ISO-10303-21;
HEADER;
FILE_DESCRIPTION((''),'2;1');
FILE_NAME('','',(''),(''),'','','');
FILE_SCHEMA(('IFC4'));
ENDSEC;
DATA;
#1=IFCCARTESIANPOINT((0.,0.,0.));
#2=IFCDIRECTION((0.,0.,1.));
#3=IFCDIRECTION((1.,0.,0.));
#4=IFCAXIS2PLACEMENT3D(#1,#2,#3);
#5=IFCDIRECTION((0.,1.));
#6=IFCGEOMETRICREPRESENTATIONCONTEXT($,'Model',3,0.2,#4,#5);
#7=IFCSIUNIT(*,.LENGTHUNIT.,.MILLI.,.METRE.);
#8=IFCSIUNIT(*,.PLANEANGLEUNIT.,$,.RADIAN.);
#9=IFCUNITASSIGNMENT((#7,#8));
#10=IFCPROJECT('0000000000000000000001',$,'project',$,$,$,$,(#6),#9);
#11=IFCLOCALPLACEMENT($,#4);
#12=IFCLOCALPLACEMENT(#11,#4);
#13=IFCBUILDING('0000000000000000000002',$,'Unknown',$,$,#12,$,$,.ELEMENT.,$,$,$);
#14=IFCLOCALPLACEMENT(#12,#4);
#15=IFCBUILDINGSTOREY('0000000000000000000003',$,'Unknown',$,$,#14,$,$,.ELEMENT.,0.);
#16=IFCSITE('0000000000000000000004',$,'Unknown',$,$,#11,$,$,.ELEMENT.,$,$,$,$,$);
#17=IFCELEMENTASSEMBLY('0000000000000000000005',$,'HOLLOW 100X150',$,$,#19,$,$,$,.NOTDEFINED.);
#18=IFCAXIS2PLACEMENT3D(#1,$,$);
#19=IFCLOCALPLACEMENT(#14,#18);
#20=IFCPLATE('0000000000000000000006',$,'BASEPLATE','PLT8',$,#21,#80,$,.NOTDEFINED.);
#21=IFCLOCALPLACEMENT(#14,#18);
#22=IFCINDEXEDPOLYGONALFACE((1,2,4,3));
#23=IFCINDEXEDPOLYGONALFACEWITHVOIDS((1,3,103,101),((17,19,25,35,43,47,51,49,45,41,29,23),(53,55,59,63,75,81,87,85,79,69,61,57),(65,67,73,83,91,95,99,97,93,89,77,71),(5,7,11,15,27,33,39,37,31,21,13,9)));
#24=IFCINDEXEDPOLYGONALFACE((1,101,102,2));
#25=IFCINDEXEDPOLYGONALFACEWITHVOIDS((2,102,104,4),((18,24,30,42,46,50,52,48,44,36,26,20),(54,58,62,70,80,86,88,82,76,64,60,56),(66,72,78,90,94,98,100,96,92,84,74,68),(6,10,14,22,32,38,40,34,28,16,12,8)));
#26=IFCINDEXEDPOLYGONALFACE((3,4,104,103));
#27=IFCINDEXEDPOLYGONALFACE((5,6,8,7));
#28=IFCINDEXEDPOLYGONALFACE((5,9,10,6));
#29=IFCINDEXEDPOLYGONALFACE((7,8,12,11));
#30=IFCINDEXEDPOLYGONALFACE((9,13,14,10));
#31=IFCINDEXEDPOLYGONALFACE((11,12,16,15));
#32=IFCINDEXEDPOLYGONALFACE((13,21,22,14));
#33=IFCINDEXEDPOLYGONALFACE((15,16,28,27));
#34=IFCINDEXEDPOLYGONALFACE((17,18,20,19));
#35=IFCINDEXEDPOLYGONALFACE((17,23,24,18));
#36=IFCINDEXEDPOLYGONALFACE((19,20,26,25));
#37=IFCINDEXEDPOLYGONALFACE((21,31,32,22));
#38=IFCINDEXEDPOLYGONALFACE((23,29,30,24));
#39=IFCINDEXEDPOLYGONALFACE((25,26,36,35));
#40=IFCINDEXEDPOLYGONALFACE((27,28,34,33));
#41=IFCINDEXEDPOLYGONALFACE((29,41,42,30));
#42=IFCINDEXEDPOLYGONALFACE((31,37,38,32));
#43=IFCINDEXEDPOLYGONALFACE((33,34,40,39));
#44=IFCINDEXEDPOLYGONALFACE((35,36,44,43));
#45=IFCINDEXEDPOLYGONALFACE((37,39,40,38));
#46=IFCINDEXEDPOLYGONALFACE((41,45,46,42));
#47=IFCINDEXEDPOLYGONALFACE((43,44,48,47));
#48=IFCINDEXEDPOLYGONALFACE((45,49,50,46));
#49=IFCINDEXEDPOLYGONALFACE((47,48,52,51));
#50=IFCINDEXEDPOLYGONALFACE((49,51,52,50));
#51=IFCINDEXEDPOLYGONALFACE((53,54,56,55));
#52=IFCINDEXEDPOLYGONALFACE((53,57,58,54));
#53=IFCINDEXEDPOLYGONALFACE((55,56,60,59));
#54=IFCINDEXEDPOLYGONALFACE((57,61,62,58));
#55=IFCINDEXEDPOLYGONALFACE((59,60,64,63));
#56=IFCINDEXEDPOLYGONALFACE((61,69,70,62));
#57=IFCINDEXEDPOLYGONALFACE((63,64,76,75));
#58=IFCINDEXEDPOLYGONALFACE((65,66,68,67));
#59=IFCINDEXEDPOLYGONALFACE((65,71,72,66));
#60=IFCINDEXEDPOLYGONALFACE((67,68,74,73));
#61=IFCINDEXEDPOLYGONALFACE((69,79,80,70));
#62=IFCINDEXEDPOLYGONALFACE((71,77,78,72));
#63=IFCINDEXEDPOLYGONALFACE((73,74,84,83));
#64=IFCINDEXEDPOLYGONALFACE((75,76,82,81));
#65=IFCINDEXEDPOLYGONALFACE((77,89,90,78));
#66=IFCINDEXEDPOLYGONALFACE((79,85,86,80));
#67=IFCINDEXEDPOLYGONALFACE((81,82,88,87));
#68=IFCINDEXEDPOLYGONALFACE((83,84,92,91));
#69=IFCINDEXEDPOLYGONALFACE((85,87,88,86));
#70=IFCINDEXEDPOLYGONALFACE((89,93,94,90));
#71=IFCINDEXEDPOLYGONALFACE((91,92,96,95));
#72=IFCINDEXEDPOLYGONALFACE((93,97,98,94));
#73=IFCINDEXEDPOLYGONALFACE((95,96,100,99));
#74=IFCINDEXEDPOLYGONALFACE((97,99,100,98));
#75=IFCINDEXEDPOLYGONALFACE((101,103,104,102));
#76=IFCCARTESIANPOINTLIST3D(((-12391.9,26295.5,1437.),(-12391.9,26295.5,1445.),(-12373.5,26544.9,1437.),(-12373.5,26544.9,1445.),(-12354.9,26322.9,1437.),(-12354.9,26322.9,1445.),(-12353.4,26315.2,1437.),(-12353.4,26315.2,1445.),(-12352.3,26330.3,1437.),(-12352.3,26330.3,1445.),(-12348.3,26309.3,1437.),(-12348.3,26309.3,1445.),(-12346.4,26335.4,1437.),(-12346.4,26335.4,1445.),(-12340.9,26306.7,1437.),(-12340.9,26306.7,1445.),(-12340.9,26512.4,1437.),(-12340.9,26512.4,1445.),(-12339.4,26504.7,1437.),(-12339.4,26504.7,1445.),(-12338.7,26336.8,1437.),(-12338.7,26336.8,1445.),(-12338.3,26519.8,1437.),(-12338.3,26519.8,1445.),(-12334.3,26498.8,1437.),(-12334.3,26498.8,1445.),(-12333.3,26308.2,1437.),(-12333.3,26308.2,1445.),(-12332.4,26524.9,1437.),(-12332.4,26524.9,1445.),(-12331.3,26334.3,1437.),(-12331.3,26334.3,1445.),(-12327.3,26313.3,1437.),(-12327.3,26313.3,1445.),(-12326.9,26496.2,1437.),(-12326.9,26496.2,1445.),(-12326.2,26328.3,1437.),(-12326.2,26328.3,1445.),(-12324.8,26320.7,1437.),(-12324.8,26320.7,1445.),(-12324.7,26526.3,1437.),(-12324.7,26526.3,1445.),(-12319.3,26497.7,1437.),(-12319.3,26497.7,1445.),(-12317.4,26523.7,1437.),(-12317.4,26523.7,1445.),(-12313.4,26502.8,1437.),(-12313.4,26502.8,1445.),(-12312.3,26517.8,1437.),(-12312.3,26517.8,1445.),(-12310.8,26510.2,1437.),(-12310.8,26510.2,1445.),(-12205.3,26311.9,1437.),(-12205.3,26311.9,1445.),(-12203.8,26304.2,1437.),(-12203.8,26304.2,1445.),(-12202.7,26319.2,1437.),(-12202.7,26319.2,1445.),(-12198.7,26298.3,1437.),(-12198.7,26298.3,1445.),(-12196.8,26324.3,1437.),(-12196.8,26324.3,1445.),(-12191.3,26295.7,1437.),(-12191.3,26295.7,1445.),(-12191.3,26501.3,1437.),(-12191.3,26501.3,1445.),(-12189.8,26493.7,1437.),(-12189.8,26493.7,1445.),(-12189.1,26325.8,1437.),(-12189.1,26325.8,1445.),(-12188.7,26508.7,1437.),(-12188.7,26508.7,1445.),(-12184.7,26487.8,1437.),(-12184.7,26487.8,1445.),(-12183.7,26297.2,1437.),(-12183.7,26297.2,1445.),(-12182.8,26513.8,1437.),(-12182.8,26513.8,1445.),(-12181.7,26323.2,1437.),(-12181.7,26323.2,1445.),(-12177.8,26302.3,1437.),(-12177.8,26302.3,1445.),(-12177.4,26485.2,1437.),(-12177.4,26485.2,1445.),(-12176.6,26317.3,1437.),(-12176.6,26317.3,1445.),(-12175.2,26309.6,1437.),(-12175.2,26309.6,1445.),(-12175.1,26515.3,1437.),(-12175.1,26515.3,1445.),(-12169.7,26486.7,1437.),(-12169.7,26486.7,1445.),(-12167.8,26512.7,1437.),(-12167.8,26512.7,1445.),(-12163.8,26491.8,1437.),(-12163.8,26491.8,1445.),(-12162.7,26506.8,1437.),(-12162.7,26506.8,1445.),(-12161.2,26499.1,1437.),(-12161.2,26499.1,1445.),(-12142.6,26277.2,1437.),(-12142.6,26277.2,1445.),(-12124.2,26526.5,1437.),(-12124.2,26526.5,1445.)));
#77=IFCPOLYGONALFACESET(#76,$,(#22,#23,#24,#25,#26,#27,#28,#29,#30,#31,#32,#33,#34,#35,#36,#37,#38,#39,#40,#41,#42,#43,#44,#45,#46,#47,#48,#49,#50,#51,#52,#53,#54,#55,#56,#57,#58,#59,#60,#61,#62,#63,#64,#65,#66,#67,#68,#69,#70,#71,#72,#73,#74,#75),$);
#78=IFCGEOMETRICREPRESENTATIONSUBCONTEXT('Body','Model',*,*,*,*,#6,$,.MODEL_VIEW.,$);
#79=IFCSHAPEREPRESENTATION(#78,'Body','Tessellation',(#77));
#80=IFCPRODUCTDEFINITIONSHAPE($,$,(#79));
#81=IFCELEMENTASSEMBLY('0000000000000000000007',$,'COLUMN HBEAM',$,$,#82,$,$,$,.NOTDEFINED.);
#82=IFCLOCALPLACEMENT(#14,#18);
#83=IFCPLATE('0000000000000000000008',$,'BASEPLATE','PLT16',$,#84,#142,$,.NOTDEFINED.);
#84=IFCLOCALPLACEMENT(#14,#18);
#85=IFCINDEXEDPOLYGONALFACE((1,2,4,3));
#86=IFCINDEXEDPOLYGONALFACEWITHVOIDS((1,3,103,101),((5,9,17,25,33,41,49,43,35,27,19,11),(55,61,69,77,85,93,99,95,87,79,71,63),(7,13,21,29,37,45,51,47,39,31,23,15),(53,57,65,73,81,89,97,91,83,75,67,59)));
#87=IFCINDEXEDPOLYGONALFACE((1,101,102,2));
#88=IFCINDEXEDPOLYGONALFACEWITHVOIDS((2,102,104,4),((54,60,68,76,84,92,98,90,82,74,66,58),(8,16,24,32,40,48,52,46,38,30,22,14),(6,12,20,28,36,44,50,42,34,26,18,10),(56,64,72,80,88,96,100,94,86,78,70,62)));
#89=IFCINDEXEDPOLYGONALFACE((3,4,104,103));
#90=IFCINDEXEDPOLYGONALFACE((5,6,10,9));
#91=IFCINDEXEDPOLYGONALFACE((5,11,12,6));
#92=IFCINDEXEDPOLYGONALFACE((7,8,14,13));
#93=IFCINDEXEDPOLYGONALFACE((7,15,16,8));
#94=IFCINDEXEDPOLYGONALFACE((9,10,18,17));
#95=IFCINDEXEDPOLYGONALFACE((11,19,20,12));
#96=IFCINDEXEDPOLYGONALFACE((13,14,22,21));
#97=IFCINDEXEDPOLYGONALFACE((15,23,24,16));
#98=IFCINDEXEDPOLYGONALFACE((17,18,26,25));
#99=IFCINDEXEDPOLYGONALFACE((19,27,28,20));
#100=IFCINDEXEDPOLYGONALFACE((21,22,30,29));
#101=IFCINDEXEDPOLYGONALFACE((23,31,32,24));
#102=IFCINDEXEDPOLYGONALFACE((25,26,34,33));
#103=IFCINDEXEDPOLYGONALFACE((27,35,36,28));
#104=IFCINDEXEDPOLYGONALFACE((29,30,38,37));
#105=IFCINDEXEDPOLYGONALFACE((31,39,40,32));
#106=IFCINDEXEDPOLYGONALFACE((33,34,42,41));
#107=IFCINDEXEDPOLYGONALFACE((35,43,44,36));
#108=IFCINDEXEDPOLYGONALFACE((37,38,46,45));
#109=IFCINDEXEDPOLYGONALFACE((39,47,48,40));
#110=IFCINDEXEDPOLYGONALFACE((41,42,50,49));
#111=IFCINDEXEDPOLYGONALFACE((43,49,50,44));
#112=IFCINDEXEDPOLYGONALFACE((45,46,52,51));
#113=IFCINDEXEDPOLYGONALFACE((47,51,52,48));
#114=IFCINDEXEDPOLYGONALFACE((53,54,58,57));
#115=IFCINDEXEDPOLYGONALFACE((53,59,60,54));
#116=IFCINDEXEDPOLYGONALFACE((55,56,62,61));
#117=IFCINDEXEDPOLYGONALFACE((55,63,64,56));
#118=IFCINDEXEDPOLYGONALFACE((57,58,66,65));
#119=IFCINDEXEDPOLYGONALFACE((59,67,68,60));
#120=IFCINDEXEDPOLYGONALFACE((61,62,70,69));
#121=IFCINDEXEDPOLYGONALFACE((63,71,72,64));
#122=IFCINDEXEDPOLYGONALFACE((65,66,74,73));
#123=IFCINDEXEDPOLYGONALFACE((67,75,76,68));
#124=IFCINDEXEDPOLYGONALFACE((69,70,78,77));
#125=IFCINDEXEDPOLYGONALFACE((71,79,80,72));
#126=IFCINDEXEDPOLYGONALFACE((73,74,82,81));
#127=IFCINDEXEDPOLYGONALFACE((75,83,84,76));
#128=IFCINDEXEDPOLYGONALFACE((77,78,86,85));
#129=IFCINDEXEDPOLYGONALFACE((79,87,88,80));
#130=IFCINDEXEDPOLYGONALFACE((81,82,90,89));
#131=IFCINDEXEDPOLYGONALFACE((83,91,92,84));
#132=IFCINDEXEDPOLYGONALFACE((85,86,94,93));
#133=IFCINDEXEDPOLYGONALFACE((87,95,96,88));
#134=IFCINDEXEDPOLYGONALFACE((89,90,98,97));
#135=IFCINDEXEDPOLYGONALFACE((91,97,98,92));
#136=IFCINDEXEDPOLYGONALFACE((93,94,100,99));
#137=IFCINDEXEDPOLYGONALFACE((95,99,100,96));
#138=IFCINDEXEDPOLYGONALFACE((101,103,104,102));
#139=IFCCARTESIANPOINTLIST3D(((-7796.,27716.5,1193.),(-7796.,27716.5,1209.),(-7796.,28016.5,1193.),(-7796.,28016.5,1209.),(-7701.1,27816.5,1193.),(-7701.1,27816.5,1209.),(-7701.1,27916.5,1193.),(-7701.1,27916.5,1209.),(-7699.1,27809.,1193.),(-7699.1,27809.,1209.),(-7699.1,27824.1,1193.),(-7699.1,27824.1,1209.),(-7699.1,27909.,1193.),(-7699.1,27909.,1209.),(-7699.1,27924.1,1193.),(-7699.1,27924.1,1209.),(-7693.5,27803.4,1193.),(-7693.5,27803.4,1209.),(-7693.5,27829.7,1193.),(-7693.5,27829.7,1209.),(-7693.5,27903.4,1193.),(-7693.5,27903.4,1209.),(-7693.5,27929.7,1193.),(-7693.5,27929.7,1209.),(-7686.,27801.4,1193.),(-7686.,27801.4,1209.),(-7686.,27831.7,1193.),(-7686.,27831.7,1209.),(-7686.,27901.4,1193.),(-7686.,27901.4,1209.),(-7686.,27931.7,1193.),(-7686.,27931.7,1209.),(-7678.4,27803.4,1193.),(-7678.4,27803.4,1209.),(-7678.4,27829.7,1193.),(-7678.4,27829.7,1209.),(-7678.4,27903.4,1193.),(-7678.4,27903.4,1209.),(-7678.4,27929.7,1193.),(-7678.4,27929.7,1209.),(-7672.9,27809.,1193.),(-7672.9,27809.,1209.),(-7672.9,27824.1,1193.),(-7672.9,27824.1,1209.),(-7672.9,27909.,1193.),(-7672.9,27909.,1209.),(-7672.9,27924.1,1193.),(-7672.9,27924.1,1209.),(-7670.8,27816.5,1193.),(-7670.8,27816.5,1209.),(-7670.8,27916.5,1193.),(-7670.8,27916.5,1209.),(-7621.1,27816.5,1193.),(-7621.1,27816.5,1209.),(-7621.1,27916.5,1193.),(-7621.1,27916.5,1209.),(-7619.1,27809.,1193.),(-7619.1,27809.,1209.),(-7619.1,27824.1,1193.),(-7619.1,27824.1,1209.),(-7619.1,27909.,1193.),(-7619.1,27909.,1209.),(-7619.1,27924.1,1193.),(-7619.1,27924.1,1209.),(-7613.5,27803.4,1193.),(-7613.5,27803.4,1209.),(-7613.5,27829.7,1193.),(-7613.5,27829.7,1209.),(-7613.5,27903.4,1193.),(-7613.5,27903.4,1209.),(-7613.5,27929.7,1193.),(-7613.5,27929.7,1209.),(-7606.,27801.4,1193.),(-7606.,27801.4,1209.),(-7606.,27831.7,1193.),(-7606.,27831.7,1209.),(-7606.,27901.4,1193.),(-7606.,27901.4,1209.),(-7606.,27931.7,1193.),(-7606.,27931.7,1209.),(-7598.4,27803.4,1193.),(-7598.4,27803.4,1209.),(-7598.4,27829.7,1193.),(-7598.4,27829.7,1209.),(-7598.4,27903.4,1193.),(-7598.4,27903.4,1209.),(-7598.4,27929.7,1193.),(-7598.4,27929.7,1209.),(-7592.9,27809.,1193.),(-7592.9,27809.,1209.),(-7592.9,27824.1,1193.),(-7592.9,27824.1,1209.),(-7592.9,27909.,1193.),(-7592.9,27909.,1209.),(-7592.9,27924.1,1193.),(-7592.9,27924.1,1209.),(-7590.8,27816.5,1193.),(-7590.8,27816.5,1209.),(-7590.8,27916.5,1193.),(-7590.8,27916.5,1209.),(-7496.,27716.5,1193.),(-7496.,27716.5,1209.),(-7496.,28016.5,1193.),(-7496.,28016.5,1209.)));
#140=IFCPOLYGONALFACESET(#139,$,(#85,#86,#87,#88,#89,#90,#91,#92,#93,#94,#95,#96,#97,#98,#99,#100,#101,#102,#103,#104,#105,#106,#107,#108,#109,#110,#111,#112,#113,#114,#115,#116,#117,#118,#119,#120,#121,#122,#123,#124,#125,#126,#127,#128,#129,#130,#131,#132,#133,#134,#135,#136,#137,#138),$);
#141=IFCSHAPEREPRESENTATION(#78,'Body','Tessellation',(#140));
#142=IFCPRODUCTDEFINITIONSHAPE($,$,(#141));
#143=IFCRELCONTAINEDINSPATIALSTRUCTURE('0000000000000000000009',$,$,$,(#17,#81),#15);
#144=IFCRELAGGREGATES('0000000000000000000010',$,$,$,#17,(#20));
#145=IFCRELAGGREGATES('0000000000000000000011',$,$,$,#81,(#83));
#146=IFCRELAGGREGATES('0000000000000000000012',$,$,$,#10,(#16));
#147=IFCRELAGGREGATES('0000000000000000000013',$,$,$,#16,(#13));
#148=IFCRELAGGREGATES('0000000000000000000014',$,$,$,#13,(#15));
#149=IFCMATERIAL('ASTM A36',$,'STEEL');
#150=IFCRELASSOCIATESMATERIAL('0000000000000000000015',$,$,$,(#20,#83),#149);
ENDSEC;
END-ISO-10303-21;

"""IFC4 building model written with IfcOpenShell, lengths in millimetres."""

from ifc_helpers import new_model, si_unit, direction, frame, origin_with_axes, place, context, subcontext, project, spatial, line, indexed_curve, outline, extrude, material, element, aggregate, save


model = new_model("IFC4")

# Units and contexts
model_context = context("Model", 3, precision=0.2, world=origin_with_axes(), true_north=direction((0.0, 1.0)))
body_context = subcontext(model_context, "Body", "Model", "MODEL_VIEW")
ifc_project = project(units=[si_unit("LENGTHUNIT", "METRE", prefix="MILLI"), si_unit("PLANEANGLEUNIT", "RADIAN")], contexts=[model_context])

# Site, building, storey
site_placement = place(None, origin_with_axes())
site = spatial("IfcSite", under=ifc_project, at=site_placement, Name="Unknown", CompositionType="ELEMENT")
building_placement = place(site_placement, origin_with_axes())
building = spatial("IfcBuilding", under=site, at=building_placement, Name="Unknown", CompositionType="ELEMENT")
storey_placement = place(building_placement, origin_with_axes())
storey = spatial("IfcBuildingStorey", under=building, at=storey_placement, Name="Unknown", CompositionType="ELEMENT", Elevation=0.0)

# Shared definitions
ifc_material_1 = material(Name="ASTM A36", Category="STEEL")

# Element assemblies, plates, voiding features
assembly_1_placement = place(storey_placement, frame((-12258.0, 26411.0, 1346.9), z_axis=(-0.073569, -0.99729, 0.0), x_axis=(0.0, 0.0, 1.0)))
assembly_1 = element("IfcElementAssembly", 1, at=assembly_1_placement, inside=storey, Name="HOLLOW 100X150", PredefinedType="NOTDEFINED")
plate_1_placement = place(assembly_1_placement, frame((94.1, 125.0, -125.0), z_axis=(-1.0, 0.0, 0.0), x_axis=(0.0, -1.0, 0.0)))
plate_1 = element("IfcPlate", 2, at=plate_1_placement, material=ifc_material_1, Name="BASEPLATE", Description="PLT8", PredefinedType="NOTDEFINED", context=body_context, shape_type="SolidModel", body=[
    extrude(outline(indexed_curve([(0.0, 0.0), (250.0, 0.0), (250.0, 250.0), (0.0, 250.0)], segments=[line(1, 2, 3, 4, 1)])), frame((0.0, 0.0, 4.0), z_axis=(0.0, 0.0, 1.0), x_axis=(1.0, 0.0, 0.0)), (0.0, 0.0, -1.0), 8.0),
])
voiding_feature_1_placement = place(plate_1_placement, frame((200.0, 30.0, 4.5), z_axis=(-1.0, 0.0, 0.0), x_axis=(0.0, 0.0, -1.0)))
element("IfcVoidingFeature", 3, at=voiding_feature_1_placement, cuts=plate_1, Name="BEAM", PredefinedType="HOLE", context=body_context, shape_type="SolidModel", body=[
    extrude(outline(indexed_curve([(15.1, 0.0), (13.1, 7.5), (7.5, 13.1), (0.0, 15.1), (-7.5, 13.1), (-13.1, 7.5), (-15.1, 0.0), (-13.1, -7.5), (-7.5, -13.1), (0.0, -15.1), (7.5, -13.1), (13.1, -7.5)], segments=[line(1, 2, 3, 4, 5, 6, 7, 8, 9, 10, 11, 12, 1)])), frame((0.0, 0.0, 0.0), z_axis=(-1.0, 0.0, 0.0), x_axis=(0.0, 0.0, 1.0)), (0.0, 0.0, -1.0), 9.0),
])
voiding_feature_2_placement = place(plate_1_placement, frame((50.0, 30.0, 4.5), z_axis=(-1.0, 0.0, 0.0), x_axis=(0.0, 0.0, -1.0)))
element("IfcVoidingFeature", 4, at=voiding_feature_2_placement, cuts=plate_1, Name="BEAM", PredefinedType="HOLE", context=body_context, shape_type="SolidModel", body=[
    extrude(outline(indexed_curve([(15.1, 0.0), (13.1, 7.5), (7.5, 13.1), (0.0, 15.1), (-7.5, 13.1), (-13.1, 7.5), (-15.1, 0.0), (-13.1, -7.5), (-7.5, -13.1), (0.0, -15.1), (7.5, -13.1), (13.1, -7.5)], segments=[line(1, 2, 3, 4, 5, 6, 7, 8, 9, 10, 11, 12, 1)])), frame((0.0, 0.0, 0.0), z_axis=(-1.0, 0.0, 0.0), x_axis=(0.0, 0.0, 1.0)), (0.0, 0.0, -1.0), 9.0),
])
voiding_feature_3_placement = place(plate_1_placement, frame((200.0, 220.0, 4.5), z_axis=(-1.0, 0.0, 0.0), x_axis=(0.0, 0.0, -1.0)))
element("IfcVoidingFeature", 5, at=voiding_feature_3_placement, cuts=plate_1, Name="BEAM", PredefinedType="HOLE", context=body_context, shape_type="SolidModel", body=[
    extrude(outline(indexed_curve([(15.1, 0.0), (13.1, 7.5), (7.5, 13.1), (0.0, 15.1), (-7.5, 13.1), (-13.1, 7.5), (-15.1, 0.0), (-13.1, -7.5), (-7.5, -13.1), (0.0, -15.1), (7.5, -13.1), (13.1, -7.5)], segments=[line(1, 2, 3, 4, 5, 6, 7, 8, 9, 10, 11, 12, 1)])), frame((0.0, 0.0, 0.0), z_axis=(-1.0, 0.0, 0.0), x_axis=(0.0, 0.0, 1.0)), (0.0, 0.0, -1.0), 9.0),
])
voiding_feature_4_placement = place(plate_1_placement, frame((50.0, 220.0, 4.5), z_axis=(-1.0, 0.0, 0.0), x_axis=(0.0, 0.0, -1.0)))
element("IfcVoidingFeature", 6, at=voiding_feature_4_placement, cuts=plate_1, Name="BEAM", PredefinedType="HOLE", context=body_context, shape_type="SolidModel", body=[
    extrude(outline(indexed_curve([(15.1, 0.0), (13.1, 7.5), (7.5, 13.1), (0.0, 15.1), (-7.5, 13.1), (-13.1, 7.5), (-15.1, 0.0), (-13.1, -7.5), (-7.5, -13.1), (0.0, -15.1), (7.5, -13.1), (13.1, -7.5)], segments=[line(1, 2, 3, 4, 5, 6, 7, 8, 9, 10, 11, 12, 1)])), frame((0.0, 0.0, 0.0), z_axis=(-1.0, 0.0, 0.0), x_axis=(0.0, 0.0, 1.0)), (0.0, 0.0, -1.0), 9.0),
])
aggregate(assembly_1, [plate_1])
assembly_2_placement = place(storey_placement, frame((-7668.5, 27866.5, 952.0), z_axis=(0.0, -1.0, 0.0), x_axis=(0.087153, 0.0, 0.996195)))
assembly_2 = element("IfcElementAssembly", 7, at=assembly_2_placement, inside=storey, Name="COLUMN HBEAM", PredefinedType="NOTDEFINED")
plate_2_placement = place(assembly_2_placement, frame((237.0, 148.7, 150.0), z_axis=(-0.996195, -0.087153, 0.0), x_axis=(0.0, 0.0, -1.0)))
plate_2 = element("IfcPlate", 8, at=plate_2_placement, material=ifc_material_1, Name="BASEPLATE", Description="PLT16", PredefinedType="NOTDEFINED", context=body_context, shape_type="SolidModel", body=[
    extrude(outline(indexed_curve([(0.0, 0.0), (300.0, 0.0), (300.0, 300.0), (0.0, 300.0)], segments=[line(1, 2, 3, 4, 1)])), frame((0.0, 0.0, 8.0), z_axis=(0.0, 0.0, 1.0), x_axis=(1.0, 0.0, 0.0)), (0.0, 0.0, -1.0), 16.0),
])
voiding_feature_5_placement = place(plate_2_placement, frame((200.0, 110.0, 8.5), z_axis=(-1.0, 0.0, 0.0), x_axis=(0.0, 0.0, -1.0)))
element("IfcVoidingFeature", 9, at=voiding_feature_5_placement, cuts=plate_2, Name="BEAM", PredefinedType="HOLE", context=body_context, shape_type="SolidModel", body=[
    extrude(outline(indexed_curve([(15.1, 0.0), (13.1, 7.6), (7.6, 13.1), (0.0, 15.1), (-7.6, 13.1), (-13.1, 7.6), (-15.1, 0.0), (-13.1, -7.6), (-7.6, -13.1), (0.0, -15.1), (7.6, -13.1), (13.1, -7.6)], segments=[line(1, 2, 3, 4, 5, 6, 7, 8, 9, 10, 11, 12, 1)])), frame((0.0, 0.0, 0.0), z_axis=(-1.0, 0.0, 0.0), x_axis=(0.0, 0.0, 1.0)), (0.0, 0.0, -1.0), 17.0),
])
voiding_feature_6_placement = place(plate_2_placement, frame((100.0, 110.0, 8.5), z_axis=(-1.0, 0.0, 0.0), x_axis=(0.0, 0.0, -1.0)))
element("IfcVoidingFeature", 10, at=voiding_feature_6_placement, cuts=plate_2, Name="BEAM", PredefinedType="HOLE", context=body_context, shape_type="SolidModel", body=[
    extrude(outline(indexed_curve([(15.1, 0.0), (13.1, 7.6), (7.6, 13.1), (0.0, 15.1), (-7.6, 13.1), (-13.1, 7.6), (-15.1, 0.0), (-13.1, -7.6), (-7.6, -13.1), (0.0, -15.1), (7.6, -13.1), (13.1, -7.6)], segments=[line(1, 2, 3, 4, 5, 6, 7, 8, 9, 10, 11, 12, 1)])), frame((0.0, 0.0, 0.0), z_axis=(-1.0, 0.0, 0.0), x_axis=(0.0, 0.0, 1.0)), (0.0, 0.0, -1.0), 17.0),
])
voiding_feature_7_placement = place(plate_2_placement, frame((200.0, 190.0, 8.5), z_axis=(-1.0, 0.0, 0.0), x_axis=(0.0, 0.0, -1.0)))
element("IfcVoidingFeature", 11, at=voiding_feature_7_placement, cuts=plate_2, Name="BEAM", PredefinedType="HOLE", context=body_context, shape_type="SolidModel", body=[
    extrude(outline(indexed_curve([(15.1, 0.0), (13.1, 7.6), (7.6, 13.1), (0.0, 15.1), (-7.6, 13.1), (-13.1, 7.6), (-15.1, 0.0), (-13.1, -7.6), (-7.6, -13.1), (0.0, -15.1), (7.6, -13.1), (13.1, -7.6)], segments=[line(1, 2, 3, 4, 5, 6, 7, 8, 9, 10, 11, 12, 1)])), frame((0.0, 0.0, 0.0), z_axis=(-1.0, 0.0, 0.0), x_axis=(0.0, 0.0, 1.0)), (0.0, 0.0, -1.0), 17.0),
])
voiding_feature_8_placement = place(plate_2_placement, frame((100.0, 190.0, 8.5), z_axis=(-1.0, 0.0, 0.0), x_axis=(0.0, 0.0, -1.0)))
element("IfcVoidingFeature", 12, at=voiding_feature_8_placement, cuts=plate_2, Name="BEAM", PredefinedType="HOLE", context=body_context, shape_type="SolidModel", body=[
    extrude(outline(indexed_curve([(15.1, 0.0), (13.1, 7.6), (7.6, 13.1), (0.0, 15.1), (-7.6, 13.1), (-13.1, 7.6), (-15.1, 0.0), (-13.1, -7.6), (-7.6, -13.1), (0.0, -15.1), (7.6, -13.1), (13.1, -7.6)], segments=[line(1, 2, 3, 4, 5, 6, 7, 8, 9, 10, 11, 12, 1)])), frame((0.0, 0.0, 0.0), z_axis=(-1.0, 0.0, 0.0), x_axis=(0.0, 0.0, 1.0)), (0.0, 0.0, -1.0), 17.0),
])
aggregate(assembly_2, [plate_2])

save(model, "model.ifc")
